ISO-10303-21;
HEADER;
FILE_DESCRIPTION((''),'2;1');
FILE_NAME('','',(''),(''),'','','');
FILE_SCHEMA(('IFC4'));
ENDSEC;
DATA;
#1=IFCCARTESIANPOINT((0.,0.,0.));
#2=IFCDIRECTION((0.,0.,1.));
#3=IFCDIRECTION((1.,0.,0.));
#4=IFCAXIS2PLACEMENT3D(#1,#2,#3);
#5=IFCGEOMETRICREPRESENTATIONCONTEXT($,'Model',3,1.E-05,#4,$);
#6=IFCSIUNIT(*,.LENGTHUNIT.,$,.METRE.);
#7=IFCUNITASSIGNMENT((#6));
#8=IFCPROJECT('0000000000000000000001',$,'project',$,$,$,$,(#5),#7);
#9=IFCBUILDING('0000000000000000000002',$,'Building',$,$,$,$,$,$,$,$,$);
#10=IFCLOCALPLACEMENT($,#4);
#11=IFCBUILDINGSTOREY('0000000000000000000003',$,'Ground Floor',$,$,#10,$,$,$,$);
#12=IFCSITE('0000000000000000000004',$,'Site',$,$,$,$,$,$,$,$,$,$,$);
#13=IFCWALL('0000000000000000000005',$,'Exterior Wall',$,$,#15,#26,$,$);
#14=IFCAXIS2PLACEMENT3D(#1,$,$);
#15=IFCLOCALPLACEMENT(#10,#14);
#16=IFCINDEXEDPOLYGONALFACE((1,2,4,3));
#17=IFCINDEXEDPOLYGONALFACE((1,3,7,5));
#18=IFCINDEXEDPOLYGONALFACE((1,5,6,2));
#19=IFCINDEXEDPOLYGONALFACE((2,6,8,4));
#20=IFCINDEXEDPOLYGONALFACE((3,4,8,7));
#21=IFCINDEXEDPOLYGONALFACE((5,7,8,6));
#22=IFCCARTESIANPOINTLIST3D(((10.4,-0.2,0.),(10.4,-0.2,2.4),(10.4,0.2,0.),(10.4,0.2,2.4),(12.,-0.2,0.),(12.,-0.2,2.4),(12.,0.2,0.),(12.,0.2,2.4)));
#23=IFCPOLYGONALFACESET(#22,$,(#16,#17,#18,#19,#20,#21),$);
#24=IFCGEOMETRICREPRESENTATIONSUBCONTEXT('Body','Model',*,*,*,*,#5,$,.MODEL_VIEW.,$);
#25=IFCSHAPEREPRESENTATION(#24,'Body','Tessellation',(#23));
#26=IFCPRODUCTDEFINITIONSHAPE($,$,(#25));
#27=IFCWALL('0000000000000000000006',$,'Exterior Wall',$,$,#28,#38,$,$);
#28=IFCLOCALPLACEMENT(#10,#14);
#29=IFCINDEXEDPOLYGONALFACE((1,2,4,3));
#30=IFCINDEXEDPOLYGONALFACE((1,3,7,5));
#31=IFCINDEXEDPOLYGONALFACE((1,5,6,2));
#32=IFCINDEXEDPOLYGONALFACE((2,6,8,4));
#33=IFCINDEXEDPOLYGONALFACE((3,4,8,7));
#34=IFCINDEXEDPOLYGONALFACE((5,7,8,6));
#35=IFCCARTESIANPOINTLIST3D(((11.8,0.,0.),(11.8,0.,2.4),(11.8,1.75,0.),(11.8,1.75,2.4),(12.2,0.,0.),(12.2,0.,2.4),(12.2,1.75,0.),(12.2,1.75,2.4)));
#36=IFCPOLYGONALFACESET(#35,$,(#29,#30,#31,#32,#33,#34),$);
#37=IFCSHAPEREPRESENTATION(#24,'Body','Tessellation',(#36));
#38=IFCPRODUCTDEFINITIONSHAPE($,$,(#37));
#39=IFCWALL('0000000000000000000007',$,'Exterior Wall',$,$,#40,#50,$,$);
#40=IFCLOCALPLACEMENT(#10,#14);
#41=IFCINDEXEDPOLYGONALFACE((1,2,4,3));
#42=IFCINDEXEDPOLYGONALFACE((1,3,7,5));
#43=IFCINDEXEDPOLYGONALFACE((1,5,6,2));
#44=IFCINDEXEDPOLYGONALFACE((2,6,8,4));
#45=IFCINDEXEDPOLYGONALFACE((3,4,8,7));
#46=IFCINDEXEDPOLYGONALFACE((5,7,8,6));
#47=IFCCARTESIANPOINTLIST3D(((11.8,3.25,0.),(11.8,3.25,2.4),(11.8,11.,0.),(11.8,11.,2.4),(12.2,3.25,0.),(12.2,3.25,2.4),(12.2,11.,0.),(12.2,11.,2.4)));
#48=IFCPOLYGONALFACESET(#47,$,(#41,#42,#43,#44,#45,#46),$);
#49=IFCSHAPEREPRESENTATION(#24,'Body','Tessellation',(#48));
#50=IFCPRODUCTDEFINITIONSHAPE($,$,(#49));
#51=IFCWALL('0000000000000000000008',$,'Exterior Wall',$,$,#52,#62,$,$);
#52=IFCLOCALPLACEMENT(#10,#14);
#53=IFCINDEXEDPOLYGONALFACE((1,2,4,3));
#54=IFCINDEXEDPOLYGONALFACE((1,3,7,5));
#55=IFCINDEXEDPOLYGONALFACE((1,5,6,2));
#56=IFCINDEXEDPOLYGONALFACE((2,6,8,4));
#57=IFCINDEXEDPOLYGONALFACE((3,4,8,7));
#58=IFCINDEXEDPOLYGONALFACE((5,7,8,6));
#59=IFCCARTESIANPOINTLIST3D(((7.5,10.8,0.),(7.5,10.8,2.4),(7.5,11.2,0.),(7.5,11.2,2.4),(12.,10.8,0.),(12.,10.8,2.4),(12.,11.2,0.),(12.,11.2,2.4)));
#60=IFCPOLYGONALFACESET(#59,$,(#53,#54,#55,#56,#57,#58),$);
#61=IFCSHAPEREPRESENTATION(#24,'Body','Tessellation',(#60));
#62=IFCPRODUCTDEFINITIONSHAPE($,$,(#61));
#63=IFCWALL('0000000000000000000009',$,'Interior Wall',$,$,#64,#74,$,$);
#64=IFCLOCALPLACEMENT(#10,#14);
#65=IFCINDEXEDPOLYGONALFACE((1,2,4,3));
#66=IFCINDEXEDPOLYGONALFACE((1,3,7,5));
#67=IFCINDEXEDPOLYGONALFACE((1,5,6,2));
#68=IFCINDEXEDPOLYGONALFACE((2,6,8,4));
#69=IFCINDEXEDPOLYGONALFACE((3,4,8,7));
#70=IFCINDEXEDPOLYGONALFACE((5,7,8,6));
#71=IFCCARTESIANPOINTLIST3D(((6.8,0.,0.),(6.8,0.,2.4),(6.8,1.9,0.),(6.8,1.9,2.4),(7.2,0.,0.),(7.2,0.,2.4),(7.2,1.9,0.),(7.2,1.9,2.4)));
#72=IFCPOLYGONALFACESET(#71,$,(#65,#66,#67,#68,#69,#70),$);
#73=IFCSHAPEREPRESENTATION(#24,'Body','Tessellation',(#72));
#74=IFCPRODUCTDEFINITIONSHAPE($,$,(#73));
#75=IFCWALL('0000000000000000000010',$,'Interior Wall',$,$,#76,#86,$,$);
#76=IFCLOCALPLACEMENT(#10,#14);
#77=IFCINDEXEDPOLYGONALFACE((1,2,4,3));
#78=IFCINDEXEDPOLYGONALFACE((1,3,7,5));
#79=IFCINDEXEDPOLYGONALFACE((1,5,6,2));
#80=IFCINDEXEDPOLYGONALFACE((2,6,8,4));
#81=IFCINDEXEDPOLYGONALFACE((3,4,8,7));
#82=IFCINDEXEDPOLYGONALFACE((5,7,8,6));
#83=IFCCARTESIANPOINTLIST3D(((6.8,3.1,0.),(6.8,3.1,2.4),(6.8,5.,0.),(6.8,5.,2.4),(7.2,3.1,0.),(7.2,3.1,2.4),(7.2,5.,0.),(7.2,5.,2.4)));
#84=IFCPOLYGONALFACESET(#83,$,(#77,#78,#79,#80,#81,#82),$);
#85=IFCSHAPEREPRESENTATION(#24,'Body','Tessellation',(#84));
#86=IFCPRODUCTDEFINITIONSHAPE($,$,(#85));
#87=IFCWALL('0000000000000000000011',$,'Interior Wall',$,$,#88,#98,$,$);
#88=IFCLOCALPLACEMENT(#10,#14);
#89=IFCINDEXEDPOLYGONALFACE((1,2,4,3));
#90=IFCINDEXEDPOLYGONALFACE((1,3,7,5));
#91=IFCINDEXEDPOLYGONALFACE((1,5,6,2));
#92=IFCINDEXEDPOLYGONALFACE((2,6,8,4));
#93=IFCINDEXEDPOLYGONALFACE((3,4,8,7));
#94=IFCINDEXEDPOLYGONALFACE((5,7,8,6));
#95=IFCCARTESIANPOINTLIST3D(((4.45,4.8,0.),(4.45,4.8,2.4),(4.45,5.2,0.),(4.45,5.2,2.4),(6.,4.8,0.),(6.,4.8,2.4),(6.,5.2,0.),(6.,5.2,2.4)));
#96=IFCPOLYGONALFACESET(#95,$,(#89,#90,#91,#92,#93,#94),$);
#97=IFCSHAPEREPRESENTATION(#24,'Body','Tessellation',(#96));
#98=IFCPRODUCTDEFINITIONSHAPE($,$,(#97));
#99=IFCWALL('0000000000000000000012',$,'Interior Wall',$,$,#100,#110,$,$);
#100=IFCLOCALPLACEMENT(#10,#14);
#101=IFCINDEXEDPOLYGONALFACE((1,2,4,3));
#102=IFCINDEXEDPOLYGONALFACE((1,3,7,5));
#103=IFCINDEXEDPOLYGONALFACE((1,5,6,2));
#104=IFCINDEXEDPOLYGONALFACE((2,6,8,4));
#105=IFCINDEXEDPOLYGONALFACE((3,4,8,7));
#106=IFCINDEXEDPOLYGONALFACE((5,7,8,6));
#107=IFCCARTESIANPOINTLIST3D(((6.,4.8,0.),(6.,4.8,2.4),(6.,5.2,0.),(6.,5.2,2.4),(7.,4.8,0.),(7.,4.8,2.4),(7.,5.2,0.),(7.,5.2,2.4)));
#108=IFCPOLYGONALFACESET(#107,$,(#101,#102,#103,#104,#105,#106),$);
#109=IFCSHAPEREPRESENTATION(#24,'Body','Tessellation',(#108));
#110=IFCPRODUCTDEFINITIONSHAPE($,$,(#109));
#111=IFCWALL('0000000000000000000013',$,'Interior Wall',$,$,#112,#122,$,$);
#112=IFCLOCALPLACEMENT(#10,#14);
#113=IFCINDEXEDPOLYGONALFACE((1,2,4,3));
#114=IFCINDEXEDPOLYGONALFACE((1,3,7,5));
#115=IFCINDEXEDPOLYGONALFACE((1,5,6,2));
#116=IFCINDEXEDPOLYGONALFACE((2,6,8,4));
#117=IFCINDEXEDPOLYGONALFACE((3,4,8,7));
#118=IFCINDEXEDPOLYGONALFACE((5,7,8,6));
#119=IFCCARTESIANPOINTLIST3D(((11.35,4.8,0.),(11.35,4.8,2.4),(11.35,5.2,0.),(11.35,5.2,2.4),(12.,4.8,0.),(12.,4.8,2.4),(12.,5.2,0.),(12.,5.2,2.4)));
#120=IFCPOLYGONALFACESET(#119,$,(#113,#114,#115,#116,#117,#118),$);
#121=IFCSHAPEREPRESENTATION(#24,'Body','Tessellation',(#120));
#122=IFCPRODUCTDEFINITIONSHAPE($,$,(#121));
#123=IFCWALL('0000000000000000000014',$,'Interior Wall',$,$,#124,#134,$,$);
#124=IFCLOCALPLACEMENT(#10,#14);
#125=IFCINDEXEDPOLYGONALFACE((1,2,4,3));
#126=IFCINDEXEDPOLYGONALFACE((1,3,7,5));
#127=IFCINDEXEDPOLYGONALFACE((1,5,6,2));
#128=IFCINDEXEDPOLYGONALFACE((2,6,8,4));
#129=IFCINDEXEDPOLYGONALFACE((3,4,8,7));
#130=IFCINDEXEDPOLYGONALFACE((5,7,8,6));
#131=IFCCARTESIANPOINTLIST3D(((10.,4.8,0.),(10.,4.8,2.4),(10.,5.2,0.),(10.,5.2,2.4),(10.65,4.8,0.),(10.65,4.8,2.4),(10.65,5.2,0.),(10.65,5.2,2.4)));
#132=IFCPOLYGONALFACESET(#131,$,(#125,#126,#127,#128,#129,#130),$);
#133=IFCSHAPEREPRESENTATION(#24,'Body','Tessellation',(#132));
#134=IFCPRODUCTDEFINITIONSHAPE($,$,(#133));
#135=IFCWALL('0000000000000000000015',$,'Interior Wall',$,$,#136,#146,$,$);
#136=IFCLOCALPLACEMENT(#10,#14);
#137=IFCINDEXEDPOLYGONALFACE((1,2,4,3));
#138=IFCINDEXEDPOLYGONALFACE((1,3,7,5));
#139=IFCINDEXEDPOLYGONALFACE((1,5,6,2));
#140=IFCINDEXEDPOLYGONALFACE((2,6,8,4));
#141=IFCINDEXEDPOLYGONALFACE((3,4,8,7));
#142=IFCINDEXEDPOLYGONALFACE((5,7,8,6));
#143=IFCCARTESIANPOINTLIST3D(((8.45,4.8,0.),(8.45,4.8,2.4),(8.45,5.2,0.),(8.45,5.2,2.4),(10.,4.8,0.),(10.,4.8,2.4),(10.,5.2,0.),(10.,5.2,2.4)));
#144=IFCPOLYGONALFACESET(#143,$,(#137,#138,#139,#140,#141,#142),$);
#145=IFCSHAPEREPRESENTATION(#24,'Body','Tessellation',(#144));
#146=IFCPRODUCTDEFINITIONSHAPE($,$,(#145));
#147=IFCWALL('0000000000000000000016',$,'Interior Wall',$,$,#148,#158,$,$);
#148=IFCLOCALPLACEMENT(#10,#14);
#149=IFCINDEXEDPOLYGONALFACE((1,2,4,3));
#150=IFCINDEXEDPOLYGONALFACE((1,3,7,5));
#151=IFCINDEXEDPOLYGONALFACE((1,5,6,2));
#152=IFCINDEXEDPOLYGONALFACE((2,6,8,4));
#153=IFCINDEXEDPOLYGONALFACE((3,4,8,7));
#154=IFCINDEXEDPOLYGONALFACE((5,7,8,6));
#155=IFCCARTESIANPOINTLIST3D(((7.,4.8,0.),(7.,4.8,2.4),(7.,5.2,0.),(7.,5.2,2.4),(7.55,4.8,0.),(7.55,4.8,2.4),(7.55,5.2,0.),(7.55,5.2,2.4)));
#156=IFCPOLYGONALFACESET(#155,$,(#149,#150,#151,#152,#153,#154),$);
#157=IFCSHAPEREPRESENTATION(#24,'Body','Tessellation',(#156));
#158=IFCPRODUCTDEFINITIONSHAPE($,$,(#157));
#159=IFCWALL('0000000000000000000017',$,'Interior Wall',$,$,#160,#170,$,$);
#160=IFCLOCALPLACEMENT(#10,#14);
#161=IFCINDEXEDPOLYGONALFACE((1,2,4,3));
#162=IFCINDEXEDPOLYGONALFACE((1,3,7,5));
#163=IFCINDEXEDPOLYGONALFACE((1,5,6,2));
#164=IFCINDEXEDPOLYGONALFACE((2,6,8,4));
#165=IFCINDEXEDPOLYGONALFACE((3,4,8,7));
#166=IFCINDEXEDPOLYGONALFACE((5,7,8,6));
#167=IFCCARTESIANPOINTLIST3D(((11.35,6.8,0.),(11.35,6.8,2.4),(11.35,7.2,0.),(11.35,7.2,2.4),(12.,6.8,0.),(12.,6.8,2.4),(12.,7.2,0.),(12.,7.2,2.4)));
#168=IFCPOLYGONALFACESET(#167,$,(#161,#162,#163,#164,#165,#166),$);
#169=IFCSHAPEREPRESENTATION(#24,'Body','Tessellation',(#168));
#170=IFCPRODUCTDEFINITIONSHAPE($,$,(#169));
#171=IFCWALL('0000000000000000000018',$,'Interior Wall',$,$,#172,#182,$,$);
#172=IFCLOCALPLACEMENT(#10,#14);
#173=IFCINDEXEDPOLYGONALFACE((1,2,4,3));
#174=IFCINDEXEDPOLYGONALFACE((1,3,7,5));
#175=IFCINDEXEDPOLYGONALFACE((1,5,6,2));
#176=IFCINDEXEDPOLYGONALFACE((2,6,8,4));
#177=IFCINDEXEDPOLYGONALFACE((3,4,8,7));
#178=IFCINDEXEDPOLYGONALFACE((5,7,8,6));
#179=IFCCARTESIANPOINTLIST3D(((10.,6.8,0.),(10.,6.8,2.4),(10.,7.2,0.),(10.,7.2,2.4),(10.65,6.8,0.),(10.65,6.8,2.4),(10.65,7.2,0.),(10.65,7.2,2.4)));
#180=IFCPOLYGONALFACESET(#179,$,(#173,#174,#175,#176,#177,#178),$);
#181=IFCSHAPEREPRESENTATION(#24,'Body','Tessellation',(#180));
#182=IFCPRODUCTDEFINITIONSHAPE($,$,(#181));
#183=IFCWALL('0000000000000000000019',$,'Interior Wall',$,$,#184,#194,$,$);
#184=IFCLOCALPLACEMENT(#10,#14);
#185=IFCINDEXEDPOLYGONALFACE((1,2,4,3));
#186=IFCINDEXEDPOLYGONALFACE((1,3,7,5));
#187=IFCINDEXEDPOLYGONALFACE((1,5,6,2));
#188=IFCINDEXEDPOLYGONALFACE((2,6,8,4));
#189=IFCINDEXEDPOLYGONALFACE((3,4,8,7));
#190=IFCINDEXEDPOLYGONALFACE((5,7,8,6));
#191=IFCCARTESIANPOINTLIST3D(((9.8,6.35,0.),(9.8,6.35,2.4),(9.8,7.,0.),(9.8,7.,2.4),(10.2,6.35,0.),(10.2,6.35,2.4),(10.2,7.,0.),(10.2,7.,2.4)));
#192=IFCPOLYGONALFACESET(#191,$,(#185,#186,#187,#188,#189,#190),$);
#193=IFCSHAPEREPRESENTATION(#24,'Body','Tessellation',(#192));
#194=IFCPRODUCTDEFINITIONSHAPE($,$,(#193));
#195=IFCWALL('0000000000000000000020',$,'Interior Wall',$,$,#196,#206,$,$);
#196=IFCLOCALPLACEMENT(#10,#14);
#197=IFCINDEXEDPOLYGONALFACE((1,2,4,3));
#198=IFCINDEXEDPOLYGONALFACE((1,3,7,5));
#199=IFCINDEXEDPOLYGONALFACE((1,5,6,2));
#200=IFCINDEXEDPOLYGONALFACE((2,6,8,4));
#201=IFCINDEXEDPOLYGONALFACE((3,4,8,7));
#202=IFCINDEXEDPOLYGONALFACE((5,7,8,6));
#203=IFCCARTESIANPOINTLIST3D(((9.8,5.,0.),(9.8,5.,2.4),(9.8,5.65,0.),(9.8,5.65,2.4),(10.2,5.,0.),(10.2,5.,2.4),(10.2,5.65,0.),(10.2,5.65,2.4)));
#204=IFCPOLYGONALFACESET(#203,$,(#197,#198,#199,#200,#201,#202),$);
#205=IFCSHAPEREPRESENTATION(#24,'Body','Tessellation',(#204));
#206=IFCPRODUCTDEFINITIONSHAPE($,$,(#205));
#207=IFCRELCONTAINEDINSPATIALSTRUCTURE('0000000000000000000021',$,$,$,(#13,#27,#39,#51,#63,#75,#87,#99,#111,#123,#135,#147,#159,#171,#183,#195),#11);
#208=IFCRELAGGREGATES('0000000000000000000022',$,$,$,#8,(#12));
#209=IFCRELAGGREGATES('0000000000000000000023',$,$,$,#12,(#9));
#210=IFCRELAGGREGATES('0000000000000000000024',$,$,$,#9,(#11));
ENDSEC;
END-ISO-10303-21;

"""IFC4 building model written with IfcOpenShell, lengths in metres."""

from ifc_helpers import new_model, si_unit, frame, origin_with_axes, place, context, subcontext, project, spatial, indexed_curve, outline, extrude, element, save


model = new_model("IFC4")

# Units and contexts
model_context = context("Model", 3, precision=1e-05, world=origin_with_axes())
body_context = subcontext(model_context, "Body", "Model", "MODEL_VIEW")
ifc_project = project(units=[si_unit("LENGTHUNIT", "METRE")], contexts=[model_context])

# Site, building, storey
site = spatial("IfcSite", under=ifc_project, Name="Site")
building = spatial("IfcBuilding", under=site, Name="Building")
storey_placement = place(None, origin_with_axes())
storey = spatial("IfcBuildingStorey", under=building, at=storey_placement, Name="Ground Floor")

# Walls
wall_1_placement = place(storey_placement, frame((10.4, 0.0, 0.0), z_axis=(0.0, 0.0, 1.0), x_axis=(1.0, 0.0, 0.0)))
element("IfcWall", 1, at=wall_1_placement, inside=storey, Name="Exterior Wall", context=body_context, shape_type="SweptSolid", body=[
    extrude(outline(indexed_curve([(0.0, 0.0), (0.0, 0.4), (1.6, 0.4), (1.6, 0.0), (0.0, 0.0)], self_intersect=False)), frame((0.0, -0.2, 0.0), z_axis=(0.0, 0.0, 1.0), x_axis=(1.0, 0.0, 0.0)), (0.0, 0.0, 1.0), 2.4),
])
wall_2_placement = place(storey_placement, frame((12.0, 0.0, 0.0), z_axis=(0.0, 0.0, 1.0), x_axis=(0.0, 1.0, 0.0)))
element("IfcWall", 2, at=wall_2_placement, inside=storey, Name="Exterior Wall", context=body_context, shape_type="SweptSolid", body=[
    extrude(outline(indexed_curve([(0.0, 0.0), (0.0, 0.4), (1.75, 0.4), (1.75, 0.0), (0.0, 0.0)], self_intersect=False)), frame((0.0, -0.2, 0.0), z_axis=(0.0, 0.0, 1.0), x_axis=(1.0, 0.0, 0.0)), (0.0, 0.0, 1.0), 2.4),
])
wall_3_placement = place(storey_placement, frame((12.0, 3.25, 0.0), z_axis=(0.0, 0.0, 1.0), x_axis=(0.0, 1.0, 0.0)))
element("IfcWall", 3, at=wall_3_placement, inside=storey, Name="Exterior Wall", context=body_context, shape_type="SweptSolid", body=[
    extrude(outline(indexed_curve([(0.0, 0.0), (0.0, 0.4), (7.75, 0.4), (7.75, 0.0), (0.0, 0.0)], self_intersect=False)), frame((0.0, -0.2, 0.0), z_axis=(0.0, 0.0, 1.0), x_axis=(1.0, 0.0, 0.0)), (0.0, 0.0, 1.0), 2.4),
])
wall_4_placement = place(storey_placement, frame((12.0, 11.0, 0.0), z_axis=(0.0, 0.0, 1.0), x_axis=(-1.0, 0.0, 0.0)))
element("IfcWall", 4, at=wall_4_placement, inside=storey, Name="Exterior Wall", context=body_context, shape_type="SweptSolid", body=[
    extrude(outline(indexed_curve([(0.0, 0.0), (0.0, 0.4), (4.5, 0.4), (4.5, 0.0), (0.0, 0.0)], self_intersect=False)), frame((0.0, -0.2, 0.0), z_axis=(0.0, 0.0, 1.0), x_axis=(1.0, 0.0, 0.0)), (0.0, 0.0, 1.0), 2.4),
])
for number, where, z_axis, x_axis, name in (
    (5, (7.0, 0.0, 0.0), (0.0, 0.0, 1.0), (0.0, 1.0, 0.0), "Interior Wall"),
    (6, (7.0, 3.1, 0.0), (0.0, 0.0, 1.0), (0.0, 1.0, 0.0), "Interior Wall"),
):
    element("IfcWall", number, at=place(storey_placement, frame(where, z_axis=z_axis, x_axis=x_axis)), inside=storey, Name=name, context=body_context, shape_type="SweptSolid", body=[
        extrude(outline(indexed_curve([(0.0, 0.0), (0.0, 0.4), (1.9, 0.4), (1.9, 0.0), (0.0, 0.0)], self_intersect=False)), frame((0.0, -0.2, 0.0), z_axis=(0.0, 0.0, 1.0), x_axis=(1.0, 0.0, 0.0)), (0.0, 0.0, 1.0), 2.4),
    ])
wall_5_placement = place(storey_placement, frame((6.0, 5.0, 0.0), z_axis=(0.0, 0.0, 1.0), x_axis=(-1.0, 0.0, 0.0)))
element("IfcWall", 7, at=wall_5_placement, inside=storey, Name="Interior Wall", context=body_context, shape_type="SweptSolid", body=[
    extrude(outline(indexed_curve([(0.0, 0.0), (0.0, 0.4), (1.55, 0.4), (1.55, 0.0), (0.0, 0.0)], self_intersect=False)), frame((0.0, -0.2, 0.0), z_axis=(0.0, 0.0, 1.0), x_axis=(1.0, 0.0, 0.0)), (0.0, 0.0, 1.0), 2.4),
])
wall_6_placement = place(storey_placement, frame((7.0, 5.0, 0.0), z_axis=(0.0, 0.0, 1.0), x_axis=(-1.0, 0.0, 0.0)))
element("IfcWall", 8, at=wall_6_placement, inside=storey, Name="Interior Wall", context=body_context, shape_type="SweptSolid", body=[
    extrude(outline(indexed_curve([(0.0, 0.0), (0.0, 0.4), (1.0, 0.4), (1.0, 0.0), (0.0, 0.0)], self_intersect=False)), frame((0.0, -0.2, 0.0), z_axis=(0.0, 0.0, 1.0), x_axis=(1.0, 0.0, 0.0)), (0.0, 0.0, 1.0), 2.4),
])
for number, where, z_axis, x_axis, name in (
    (9, (12.0, 5.0, 0.0), (0.0, 0.0, 1.0), (-1.0, 0.0, 0.0), "Interior Wall"),
    (10, (10.65, 5.0, 0.0), (0.0, 0.0, 1.0), (-1.0, 0.0, 0.0), "Interior Wall"),
):
    element("IfcWall", number, at=place(storey_placement, frame(where, z_axis=z_axis, x_axis=x_axis)), inside=storey, Name=name, context=body_context, shape_type="SweptSolid", body=[
        extrude(outline(indexed_curve([(0.0, 0.0), (0.0, 0.4), (0.65, 0.4), (0.65, 0.0), (0.0, 0.0)], self_intersect=False)), frame((0.0, -0.2, 0.0), z_axis=(0.0, 0.0, 1.0), x_axis=(1.0, 0.0, 0.0)), (0.0, 0.0, 1.0), 2.4),
    ])
wall_7_placement = place(storey_placement, frame((10.0, 5.0, 0.0), z_axis=(0.0, 0.0, 1.0), x_axis=(-1.0, 0.0, 0.0)))
element("IfcWall", 11, at=wall_7_placement, inside=storey, Name="Interior Wall", context=body_context, shape_type="SweptSolid", body=[
    extrude(outline(indexed_curve([(0.0, 0.0), (0.0, 0.4), (1.55, 0.4), (1.55, 0.0), (0.0, 0.0)], self_intersect=False)), frame((0.0, -0.2, 0.0), z_axis=(0.0, 0.0, 1.0), x_axis=(1.0, 0.0, 0.0)), (0.0, 0.0, 1.0), 2.4),
])
wall_8_placement = place(storey_placement, frame((7.55, 5.0, 0.0), z_axis=(0.0, 0.0, 1.0), x_axis=(-1.0, 0.0, 0.0)))
element("IfcWall", 12, at=wall_8_placement, inside=storey, Name="Interior Wall", context=body_context, shape_type="SweptSolid", body=[
    extrude(outline(indexed_curve([(0.0, 0.0), (0.0, 0.4), (0.55, 0.4), (0.55, 0.0), (0.0, 0.0)], self_intersect=False)), frame((0.0, -0.2, 0.0), z_axis=(0.0, 0.0, 1.0), x_axis=(1.0, 0.0, 0.0)), (0.0, 0.0, 1.0), 2.4),
])
for number, where, z_axis, x_axis, name in (
    (13, (12.0, 7.0, 0.0), (0.0, 0.0, 1.0), (-1.0, 0.0, 0.0), "Interior Wall"),
    (14, (10.65, 7.0, 0.0), (0.0, 0.0, 1.0), (-1.0, 0.0, 0.0), "Interior Wall"),
    (15, (10.0, 7.0, 0.0), (0.0, 0.0, 1.0), (0.0, -1.0, 0.0), "Interior Wall"),
    (16, (10.0, 5.65, 0.0), (0.0, 0.0, 1.0), (0.0, -1.0, 0.0), "Interior Wall"),
):
    element("IfcWall", number, at=place(storey_placement, frame(where, z_axis=z_axis, x_axis=x_axis)), inside=storey, Name=name, context=body_context, shape_type="SweptSolid", body=[
        extrude(outline(indexed_curve([(0.0, 0.0), (0.0, 0.4), (0.65, 0.4), (0.65, 0.0), (0.0, 0.0)], self_intersect=False)), frame((0.0, -0.2, 0.0), z_axis=(0.0, 0.0, 1.0), x_axis=(1.0, 0.0, 0.0)), (0.0, 0.0, 1.0), 2.4),
    ])

save(model, "model.ifc")
